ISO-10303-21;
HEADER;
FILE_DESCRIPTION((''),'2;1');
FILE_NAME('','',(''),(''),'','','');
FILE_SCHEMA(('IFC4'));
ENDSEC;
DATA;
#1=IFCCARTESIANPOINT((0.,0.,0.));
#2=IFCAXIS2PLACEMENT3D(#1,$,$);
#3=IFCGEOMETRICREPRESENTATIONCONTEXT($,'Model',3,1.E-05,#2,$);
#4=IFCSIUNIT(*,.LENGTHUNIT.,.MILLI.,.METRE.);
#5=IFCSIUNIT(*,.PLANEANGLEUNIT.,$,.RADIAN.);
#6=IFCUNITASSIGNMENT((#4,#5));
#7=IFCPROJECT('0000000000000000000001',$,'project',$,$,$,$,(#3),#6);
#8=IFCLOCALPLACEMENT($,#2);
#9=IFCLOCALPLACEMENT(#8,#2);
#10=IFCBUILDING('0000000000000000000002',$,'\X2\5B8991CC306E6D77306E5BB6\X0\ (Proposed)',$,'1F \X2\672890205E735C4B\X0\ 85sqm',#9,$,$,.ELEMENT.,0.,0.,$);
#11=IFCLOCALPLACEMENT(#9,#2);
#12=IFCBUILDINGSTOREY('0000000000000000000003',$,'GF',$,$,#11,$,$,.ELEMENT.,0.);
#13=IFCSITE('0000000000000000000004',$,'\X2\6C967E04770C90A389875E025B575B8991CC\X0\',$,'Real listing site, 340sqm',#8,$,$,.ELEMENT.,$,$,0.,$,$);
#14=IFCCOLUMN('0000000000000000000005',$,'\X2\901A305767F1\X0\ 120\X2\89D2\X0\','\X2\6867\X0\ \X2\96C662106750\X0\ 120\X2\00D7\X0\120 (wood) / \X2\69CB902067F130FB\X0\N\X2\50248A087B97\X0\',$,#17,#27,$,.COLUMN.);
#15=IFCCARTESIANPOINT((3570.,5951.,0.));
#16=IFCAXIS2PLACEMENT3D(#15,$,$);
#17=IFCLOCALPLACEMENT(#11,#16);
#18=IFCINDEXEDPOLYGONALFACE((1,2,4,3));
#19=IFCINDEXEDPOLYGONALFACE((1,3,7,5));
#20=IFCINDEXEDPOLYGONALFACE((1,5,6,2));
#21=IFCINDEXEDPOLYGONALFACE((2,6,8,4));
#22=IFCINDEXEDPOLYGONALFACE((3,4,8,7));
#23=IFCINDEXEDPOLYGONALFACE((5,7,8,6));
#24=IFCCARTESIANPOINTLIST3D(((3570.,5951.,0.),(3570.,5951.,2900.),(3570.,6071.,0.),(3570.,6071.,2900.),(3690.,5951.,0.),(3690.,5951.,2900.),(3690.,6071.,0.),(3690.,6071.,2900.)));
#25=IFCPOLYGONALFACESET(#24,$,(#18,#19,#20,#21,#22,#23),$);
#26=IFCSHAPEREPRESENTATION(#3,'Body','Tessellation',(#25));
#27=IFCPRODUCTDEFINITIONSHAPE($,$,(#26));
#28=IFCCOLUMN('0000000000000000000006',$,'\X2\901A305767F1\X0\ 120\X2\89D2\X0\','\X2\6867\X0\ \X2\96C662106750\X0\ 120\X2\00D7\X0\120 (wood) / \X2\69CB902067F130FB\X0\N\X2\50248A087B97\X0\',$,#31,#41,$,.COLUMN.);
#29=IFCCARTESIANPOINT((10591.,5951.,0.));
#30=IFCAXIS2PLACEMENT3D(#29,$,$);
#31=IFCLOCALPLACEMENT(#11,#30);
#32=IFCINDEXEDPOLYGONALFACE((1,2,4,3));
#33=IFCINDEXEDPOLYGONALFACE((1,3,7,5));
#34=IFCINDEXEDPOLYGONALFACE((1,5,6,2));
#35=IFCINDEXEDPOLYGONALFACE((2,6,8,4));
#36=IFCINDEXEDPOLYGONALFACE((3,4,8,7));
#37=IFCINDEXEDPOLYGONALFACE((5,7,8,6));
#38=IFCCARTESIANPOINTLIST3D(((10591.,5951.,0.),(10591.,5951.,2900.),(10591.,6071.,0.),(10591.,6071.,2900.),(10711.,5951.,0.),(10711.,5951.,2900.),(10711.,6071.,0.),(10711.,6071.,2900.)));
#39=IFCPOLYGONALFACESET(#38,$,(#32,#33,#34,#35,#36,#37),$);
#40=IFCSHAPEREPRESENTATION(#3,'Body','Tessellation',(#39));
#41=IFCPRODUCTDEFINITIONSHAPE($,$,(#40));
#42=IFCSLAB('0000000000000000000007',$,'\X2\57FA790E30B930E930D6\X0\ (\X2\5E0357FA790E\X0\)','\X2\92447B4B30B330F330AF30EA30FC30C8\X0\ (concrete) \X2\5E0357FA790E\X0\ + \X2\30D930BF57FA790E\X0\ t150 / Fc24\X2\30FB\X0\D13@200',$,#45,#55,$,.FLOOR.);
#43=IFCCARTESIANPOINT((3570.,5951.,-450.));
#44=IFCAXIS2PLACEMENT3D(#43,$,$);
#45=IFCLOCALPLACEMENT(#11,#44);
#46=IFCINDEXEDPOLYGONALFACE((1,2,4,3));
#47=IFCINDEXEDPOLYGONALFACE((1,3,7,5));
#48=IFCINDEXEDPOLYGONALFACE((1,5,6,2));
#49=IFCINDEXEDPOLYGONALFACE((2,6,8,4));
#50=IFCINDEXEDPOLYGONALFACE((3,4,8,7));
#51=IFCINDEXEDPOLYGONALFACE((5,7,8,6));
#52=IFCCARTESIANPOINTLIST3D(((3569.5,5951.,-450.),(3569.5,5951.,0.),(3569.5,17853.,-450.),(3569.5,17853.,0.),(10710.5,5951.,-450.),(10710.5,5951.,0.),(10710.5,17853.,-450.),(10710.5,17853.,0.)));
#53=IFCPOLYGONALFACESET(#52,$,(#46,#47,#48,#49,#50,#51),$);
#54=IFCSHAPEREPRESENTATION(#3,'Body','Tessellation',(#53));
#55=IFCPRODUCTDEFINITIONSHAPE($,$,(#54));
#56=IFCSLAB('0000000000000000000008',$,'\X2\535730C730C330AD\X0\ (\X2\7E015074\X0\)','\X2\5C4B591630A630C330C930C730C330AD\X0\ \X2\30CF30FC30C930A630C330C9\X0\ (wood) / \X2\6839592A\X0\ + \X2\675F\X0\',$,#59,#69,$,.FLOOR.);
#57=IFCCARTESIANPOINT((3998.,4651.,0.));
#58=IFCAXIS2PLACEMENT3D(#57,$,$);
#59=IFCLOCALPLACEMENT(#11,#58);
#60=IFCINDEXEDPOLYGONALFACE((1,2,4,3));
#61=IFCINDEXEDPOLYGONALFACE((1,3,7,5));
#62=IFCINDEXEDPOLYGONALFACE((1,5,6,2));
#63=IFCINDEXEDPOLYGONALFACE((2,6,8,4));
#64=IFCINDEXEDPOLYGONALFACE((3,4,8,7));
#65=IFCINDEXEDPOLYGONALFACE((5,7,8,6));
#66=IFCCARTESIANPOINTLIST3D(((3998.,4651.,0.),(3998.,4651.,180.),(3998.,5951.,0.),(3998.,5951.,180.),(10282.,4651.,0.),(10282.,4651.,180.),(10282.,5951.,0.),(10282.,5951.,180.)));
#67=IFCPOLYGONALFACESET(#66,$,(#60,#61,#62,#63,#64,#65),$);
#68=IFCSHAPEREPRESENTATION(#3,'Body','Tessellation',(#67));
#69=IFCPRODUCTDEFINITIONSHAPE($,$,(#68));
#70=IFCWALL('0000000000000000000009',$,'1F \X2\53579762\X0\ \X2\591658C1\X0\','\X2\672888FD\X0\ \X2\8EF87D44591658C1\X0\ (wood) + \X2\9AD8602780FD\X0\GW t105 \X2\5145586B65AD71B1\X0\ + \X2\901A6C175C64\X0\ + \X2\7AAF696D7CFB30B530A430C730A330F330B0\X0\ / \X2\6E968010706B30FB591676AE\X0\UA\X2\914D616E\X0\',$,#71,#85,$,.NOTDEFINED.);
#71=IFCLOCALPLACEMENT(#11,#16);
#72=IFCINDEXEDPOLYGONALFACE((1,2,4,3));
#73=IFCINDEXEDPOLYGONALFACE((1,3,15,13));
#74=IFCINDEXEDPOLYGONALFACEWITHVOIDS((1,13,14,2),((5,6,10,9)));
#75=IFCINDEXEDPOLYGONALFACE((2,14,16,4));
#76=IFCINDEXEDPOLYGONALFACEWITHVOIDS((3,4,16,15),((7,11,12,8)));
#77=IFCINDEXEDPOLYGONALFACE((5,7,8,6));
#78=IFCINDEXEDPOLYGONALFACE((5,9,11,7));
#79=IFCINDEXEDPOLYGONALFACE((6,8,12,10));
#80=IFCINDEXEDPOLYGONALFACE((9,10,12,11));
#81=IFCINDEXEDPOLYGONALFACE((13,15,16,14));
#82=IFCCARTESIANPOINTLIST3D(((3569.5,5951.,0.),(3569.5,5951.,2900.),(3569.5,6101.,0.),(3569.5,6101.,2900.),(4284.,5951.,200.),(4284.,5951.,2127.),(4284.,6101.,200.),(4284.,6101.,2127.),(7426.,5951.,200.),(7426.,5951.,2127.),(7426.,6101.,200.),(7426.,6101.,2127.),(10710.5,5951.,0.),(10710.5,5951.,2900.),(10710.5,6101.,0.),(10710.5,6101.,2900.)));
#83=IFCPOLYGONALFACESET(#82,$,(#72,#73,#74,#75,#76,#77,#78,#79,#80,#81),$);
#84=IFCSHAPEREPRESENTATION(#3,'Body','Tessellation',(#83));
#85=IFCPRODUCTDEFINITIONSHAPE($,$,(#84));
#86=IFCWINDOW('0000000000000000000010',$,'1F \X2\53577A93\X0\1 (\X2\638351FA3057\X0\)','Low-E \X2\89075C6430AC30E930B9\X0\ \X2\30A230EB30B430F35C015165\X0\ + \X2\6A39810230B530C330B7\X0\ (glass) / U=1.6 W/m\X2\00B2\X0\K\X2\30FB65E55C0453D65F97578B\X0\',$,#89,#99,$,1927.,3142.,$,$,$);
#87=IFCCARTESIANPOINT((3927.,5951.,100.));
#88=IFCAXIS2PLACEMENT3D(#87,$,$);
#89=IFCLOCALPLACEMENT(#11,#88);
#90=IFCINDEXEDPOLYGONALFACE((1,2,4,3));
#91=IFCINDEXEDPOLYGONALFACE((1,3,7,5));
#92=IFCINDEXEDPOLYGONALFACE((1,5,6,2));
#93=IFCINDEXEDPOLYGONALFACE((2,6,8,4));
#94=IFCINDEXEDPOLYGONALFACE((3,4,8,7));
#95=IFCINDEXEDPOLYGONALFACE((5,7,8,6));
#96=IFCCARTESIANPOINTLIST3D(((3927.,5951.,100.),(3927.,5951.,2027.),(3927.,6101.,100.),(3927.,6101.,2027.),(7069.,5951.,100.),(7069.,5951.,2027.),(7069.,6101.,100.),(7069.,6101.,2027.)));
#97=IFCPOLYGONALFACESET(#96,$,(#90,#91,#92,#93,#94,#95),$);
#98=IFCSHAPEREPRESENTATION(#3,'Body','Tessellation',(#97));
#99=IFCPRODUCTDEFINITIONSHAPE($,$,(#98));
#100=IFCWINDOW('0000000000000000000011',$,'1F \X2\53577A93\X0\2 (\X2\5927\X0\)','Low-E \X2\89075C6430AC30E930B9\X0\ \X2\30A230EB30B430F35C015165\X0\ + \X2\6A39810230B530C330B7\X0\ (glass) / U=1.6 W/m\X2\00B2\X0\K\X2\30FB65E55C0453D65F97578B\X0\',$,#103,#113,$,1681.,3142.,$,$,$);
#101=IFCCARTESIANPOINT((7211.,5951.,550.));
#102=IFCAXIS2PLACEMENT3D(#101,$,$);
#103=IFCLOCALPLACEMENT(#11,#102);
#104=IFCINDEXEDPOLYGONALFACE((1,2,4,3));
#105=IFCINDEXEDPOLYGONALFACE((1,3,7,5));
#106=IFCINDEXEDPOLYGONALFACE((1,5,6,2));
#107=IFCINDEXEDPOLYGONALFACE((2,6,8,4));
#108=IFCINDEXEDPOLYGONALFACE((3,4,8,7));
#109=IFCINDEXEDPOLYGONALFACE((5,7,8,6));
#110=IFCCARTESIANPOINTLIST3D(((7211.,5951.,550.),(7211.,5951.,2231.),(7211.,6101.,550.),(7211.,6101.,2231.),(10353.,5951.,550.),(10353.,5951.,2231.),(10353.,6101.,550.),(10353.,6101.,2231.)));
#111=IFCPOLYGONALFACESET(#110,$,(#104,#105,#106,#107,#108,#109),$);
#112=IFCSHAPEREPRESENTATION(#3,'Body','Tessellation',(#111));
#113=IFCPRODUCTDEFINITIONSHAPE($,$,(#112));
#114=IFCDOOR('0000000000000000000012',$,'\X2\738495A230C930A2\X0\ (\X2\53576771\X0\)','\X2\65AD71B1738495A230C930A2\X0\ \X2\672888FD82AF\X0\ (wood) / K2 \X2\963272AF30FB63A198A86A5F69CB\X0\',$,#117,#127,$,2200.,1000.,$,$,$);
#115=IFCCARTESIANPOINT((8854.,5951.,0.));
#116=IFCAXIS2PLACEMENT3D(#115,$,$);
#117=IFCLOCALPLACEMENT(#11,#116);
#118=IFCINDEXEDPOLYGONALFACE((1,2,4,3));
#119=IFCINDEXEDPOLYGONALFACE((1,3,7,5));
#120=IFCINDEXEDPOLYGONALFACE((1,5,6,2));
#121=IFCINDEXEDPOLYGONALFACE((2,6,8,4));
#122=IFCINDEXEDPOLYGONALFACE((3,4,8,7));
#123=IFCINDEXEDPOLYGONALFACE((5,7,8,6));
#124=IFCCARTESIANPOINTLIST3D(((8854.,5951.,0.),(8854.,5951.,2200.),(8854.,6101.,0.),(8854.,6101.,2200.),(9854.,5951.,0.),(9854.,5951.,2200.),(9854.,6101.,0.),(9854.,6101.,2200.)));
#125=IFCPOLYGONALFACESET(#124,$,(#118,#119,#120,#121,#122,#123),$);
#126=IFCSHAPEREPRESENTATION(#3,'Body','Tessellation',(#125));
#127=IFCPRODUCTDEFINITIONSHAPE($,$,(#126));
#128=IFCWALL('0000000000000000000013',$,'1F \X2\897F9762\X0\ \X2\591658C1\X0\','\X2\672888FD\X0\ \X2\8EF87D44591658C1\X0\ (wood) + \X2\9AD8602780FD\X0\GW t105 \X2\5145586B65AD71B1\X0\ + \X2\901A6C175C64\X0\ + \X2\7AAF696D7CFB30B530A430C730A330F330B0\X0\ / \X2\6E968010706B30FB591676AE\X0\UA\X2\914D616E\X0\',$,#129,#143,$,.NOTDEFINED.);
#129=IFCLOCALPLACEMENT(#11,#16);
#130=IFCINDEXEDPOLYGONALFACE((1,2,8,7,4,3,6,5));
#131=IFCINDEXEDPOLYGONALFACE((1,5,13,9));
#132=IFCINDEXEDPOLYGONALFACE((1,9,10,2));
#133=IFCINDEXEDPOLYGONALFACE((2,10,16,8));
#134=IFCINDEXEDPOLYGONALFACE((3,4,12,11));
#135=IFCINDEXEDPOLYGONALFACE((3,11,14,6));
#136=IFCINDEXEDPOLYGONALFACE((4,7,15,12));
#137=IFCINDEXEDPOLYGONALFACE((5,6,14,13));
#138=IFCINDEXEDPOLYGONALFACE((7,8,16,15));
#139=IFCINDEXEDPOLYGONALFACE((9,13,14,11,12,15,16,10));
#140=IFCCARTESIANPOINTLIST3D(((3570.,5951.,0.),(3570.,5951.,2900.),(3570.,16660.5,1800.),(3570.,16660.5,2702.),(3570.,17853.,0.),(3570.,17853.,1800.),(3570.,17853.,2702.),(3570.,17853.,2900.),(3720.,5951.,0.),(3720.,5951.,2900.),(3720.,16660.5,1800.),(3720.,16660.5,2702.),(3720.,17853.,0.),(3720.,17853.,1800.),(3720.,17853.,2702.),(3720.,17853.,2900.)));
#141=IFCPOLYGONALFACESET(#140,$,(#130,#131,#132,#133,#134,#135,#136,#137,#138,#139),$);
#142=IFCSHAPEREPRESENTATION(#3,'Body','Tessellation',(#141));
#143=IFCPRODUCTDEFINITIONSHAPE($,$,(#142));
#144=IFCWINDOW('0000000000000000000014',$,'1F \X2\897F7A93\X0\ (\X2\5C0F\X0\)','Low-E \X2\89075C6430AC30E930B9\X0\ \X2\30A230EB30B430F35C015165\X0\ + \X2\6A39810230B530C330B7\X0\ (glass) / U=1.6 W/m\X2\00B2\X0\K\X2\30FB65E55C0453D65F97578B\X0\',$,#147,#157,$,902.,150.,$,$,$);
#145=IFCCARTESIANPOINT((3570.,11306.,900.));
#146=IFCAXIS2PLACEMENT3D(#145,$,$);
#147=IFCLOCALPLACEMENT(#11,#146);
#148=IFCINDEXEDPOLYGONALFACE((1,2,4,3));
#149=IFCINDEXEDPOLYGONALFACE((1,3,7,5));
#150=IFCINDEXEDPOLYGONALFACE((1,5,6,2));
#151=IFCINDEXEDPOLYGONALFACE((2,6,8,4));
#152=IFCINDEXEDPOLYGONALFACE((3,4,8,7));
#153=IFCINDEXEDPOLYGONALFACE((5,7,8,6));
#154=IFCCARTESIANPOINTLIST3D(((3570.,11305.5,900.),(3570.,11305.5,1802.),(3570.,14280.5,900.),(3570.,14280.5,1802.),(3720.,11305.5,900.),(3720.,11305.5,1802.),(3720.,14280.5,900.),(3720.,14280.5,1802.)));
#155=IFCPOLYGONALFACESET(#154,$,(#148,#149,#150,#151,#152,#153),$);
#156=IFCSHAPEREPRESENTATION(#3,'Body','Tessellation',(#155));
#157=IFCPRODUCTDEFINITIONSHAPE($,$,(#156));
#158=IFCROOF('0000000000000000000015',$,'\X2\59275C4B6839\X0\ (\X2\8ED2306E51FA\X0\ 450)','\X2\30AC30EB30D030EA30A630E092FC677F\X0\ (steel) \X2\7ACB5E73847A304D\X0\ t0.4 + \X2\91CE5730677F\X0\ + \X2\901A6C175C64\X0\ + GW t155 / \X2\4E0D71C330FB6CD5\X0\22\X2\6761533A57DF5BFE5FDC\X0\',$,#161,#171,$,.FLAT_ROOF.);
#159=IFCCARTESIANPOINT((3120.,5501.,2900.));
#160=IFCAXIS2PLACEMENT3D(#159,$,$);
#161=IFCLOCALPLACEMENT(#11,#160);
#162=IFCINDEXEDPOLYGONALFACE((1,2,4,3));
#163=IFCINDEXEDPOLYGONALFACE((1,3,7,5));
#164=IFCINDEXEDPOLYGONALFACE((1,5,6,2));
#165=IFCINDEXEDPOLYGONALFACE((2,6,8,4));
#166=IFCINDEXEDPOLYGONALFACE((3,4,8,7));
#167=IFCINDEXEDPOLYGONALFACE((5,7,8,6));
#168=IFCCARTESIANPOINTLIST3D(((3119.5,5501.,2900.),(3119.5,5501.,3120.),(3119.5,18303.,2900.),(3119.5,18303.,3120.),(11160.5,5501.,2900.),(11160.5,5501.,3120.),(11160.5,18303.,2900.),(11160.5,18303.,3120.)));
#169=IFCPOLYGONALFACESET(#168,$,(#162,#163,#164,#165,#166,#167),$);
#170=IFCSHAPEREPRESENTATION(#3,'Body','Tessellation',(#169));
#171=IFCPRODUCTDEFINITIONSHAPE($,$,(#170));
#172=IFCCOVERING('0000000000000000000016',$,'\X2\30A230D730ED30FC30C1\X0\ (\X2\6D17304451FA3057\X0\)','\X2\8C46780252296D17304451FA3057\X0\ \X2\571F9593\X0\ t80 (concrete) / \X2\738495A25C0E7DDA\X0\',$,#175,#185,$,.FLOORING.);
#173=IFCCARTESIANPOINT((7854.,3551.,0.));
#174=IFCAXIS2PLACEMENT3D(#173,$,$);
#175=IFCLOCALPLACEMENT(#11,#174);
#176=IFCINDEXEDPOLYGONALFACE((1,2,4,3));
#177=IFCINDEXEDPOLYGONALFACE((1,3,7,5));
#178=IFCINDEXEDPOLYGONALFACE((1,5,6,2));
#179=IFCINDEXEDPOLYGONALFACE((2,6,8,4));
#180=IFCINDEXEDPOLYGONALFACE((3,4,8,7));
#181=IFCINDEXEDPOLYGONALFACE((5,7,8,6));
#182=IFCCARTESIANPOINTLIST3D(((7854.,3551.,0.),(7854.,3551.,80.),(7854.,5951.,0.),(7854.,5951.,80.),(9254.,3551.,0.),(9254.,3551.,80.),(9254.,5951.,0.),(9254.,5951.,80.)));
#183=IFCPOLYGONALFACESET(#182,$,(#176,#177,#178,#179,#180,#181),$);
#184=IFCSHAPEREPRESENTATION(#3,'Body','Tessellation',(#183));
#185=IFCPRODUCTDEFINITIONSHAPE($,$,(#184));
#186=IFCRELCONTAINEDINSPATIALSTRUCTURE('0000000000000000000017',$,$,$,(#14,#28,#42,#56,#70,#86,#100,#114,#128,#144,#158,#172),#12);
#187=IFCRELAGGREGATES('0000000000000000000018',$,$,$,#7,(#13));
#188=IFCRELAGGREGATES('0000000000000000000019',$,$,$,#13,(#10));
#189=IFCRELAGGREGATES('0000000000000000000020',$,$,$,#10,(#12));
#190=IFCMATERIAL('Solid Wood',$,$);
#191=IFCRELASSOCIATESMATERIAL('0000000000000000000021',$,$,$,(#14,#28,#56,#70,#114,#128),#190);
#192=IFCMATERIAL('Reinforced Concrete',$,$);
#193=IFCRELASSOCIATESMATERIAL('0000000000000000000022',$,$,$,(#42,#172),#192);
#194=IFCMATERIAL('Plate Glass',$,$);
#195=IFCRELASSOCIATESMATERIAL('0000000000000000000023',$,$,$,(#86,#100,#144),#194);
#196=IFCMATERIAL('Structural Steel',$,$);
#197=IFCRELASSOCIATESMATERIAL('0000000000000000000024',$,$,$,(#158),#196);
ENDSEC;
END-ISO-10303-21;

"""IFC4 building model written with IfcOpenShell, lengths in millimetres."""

from ifc_helpers import new_model, si_unit, frame, frame_2d, origin, place, context, project, spatial, rectangle, extrude, material, element, fill, save


model = new_model("IFC4")

# Units and contexts
model_context = context("Model", 3, precision=1e-05, world=origin())
ifc_project = project(units=[si_unit("LENGTHUNIT", "METRE", prefix="MILLI"), si_unit("PLANEANGLEUNIT", "RADIAN")], contexts=[model_context])

# Site, building, storey
site_placement = place(None, origin())
site = spatial("IfcSite", under=ifc_project, at=site_placement, Name="沖縄県那覇市字安里", ObjectType="Real listing site, 340sqm", CompositionType="ELEMENT", RefElevation=0.0)
building_placement = place(site_placement, origin())
building = spatial("IfcBuilding", under=site, at=building_placement, Name="安里の海の家 (Proposed)", ObjectType="1F 木造平屋 85sqm", CompositionType="ELEMENT", ElevationOfRefHeight=0.0, ElevationOfTerrain=0.0)
storey_placement = place(building_placement, origin())
storey = spatial("IfcBuildingStorey", under=building, at=storey_placement, Name="GF", CompositionType="ELEMENT", Elevation=0.0)

# Columns
ifc_material_1 = material(Name="Solid Wood")
column_1_placement = place(storey_placement, frame((3570.0, 5951.0, 0.0)))
element("IfcColumn", 1, at=column_1_placement, inside=storey, material=ifc_material_1, Name="通し柱 120角", Description="桧 集成材 120×120 (wood) / 構造柱・N値計算", PredefinedType="COLUMN", context=model_context, shape_type="SweptSolid", body=[
    extrude(rectangle(XDim=120.0, YDim=120.0, at=frame_2d((60.0, 60.0))), frame((3570.0, 5951.0, 0.0)), (0.0, 0.0, 1.0), 2900.0),
])
column_2_placement = place(storey_placement, frame((10591.0, 5951.0, 0.0)))
element("IfcColumn", 2, at=column_2_placement, inside=storey, material=ifc_material_1, Name="通し柱 120角", Description="桧 集成材 120×120 (wood) / 構造柱・N値計算", PredefinedType="COLUMN", context=model_context, shape_type="SweptSolid", body=[
    extrude(rectangle(XDim=120.0, YDim=120.0, at=frame_2d((60.0, 60.0))), frame((10591.0, 5951.0, 0.0)), (0.0, 0.0, 1.0), 2900.0),
])

# Slabs
ifc_material_2 = material(Name="Reinforced Concrete")
slab_1_placement = place(storey_placement, frame((3570.0, 5951.0, -450.0)))
element("IfcSlab", 3, at=slab_1_placement, inside=storey, material=ifc_material_2, Name="基礎スラブ (布基礎)", Description="鉄筋コンクリート (concrete) 布基礎 + ベタ基礎 t150 / Fc24・D13@200", PredefinedType="FLOOR", context=model_context, shape_type="SweptSolid", body=[
    extrude(rectangle(XDim=7141.0, YDim=11902.0, at=frame_2d((3570.0, 5951.0))), frame((3570.0, 5951.0, -450.0)), (0.0, 0.0, 1.0), 450.0),
])
slab_2_placement = place(storey_placement, frame((3998.0, 4651.0, 0.0)))
element("IfcSlab", 4, at=slab_2_placement, inside=storey, material=ifc_material_1, Name="南デッキ (縁側)", Description="屋外ウッドデッキ ハードウッド (wood) / 根太 + 束", PredefinedType="FLOOR", context=model_context, shape_type="SweptSolid", body=[
    extrude(rectangle(XDim=6284.0, YDim=1300.0, at=frame_2d((3142.0, 650.0))), frame((3998.0, 4651.0, 0.0)), (0.0, 0.0, 1.0), 180.0),
])

# Wall, openings, windows, door
wall_1_placement = place(storey_placement, frame((3570.0, 5951.0, 0.0)))
wall_1 = element("IfcWall", 5, at=wall_1_placement, inside=storey, material=ifc_material_1, Name="1F 南面 外壁", Description="木製 軸組外壁 (wood) + 高性能GW t105 充填断熱 + 通気層 + 窯業系サイディング / 準耐火・外皮UA配慮", PredefinedType="NOTDEFINED", context=model_context, shape_type="SweptSolid", body=[
    extrude(rectangle(XDim=7141.0, YDim=150.0, at=frame_2d((3570.0, 75.0))), frame((3570.0, 5951.0, 0.0)), (0.0, 0.0, 1.0), 2900.0),
])
opening_1_placement = place(storey_placement, frame((3927.0, 5951.0, 100.0)))
opening_1 = element("IfcOpeningElement", 6, at=opening_1_placement, cuts=wall_1, PredefinedType="NOTDEFINED", context=model_context, shape_type="SweptSolid", body=[
    extrude(rectangle(XDim=3142.0, YDim=150.0, at=frame_2d((1571.0, 75.0))), frame((3927.0, 5951.0, 100.0)), (0.0, 0.0, 1.0), 1927.0),
])
opening_2_placement = place(storey_placement, frame((7211.0, 5951.0, 550.0)))
opening_2 = element("IfcOpeningElement", 7, at=opening_2_placement, cuts=wall_1, PredefinedType="NOTDEFINED", context=model_context, shape_type="SweptSolid", body=[
    extrude(rectangle(XDim=3142.0, YDim=150.0, at=frame_2d((1571.0, 75.0))), frame((7211.0, 5951.0, 550.0)), (0.0, 0.0, 1.0), 1681.0),
])
opening_3_placement = place(storey_placement, frame((8854.0, 5951.0, 0.0)))
opening_3 = element("IfcOpeningElement", 8, at=opening_3_placement, cuts=wall_1, PredefinedType="NOTDEFINED", context=model_context, shape_type="SweptSolid", body=[
    extrude(rectangle(XDim=1000.0, YDim=150.0, at=frame_2d((500.0, 75.0))), frame((8854.0, 5951.0, 0.0)), (0.0, 0.0, 1.0), 2200.0),
])
ifc_material_3 = material(Name="Plate Glass")
window_1_placement = place(storey_placement, frame((3927.0, 5951.0, 100.0)))
window_1 = element("IfcWindow", 9, at=window_1_placement, inside=storey, material=ifc_material_3, Name="1F 南窓1 (掃出し)", Description="Low-E 複層ガラス アルゴン封入 + 樹脂サッシ (glass) / U=1.6 W/m²K・日射取得型", OverallHeight=1927.0, OverallWidth=3142.0, context=model_context, shape_type="SweptSolid", body=[
    extrude(rectangle(XDim=3142.0, YDim=150.0, at=frame_2d((1571.0, 75.0))), frame((3927.0, 5951.0, 100.0)), (0.0, 0.0, 1.0), 1927.0),
])
fill(opening_1, window_1)
window_2_placement = place(storey_placement, frame((7211.0, 5951.0, 550.0)))
window_2 = element("IfcWindow", 10, at=window_2_placement, inside=storey, material=ifc_material_3, Name="1F 南窓2 (大)", Description="Low-E 複層ガラス アルゴン封入 + 樹脂サッシ (glass) / U=1.6 W/m²K・日射取得型", OverallHeight=1681.0, OverallWidth=3142.0, context=model_context, shape_type="SweptSolid", body=[
    extrude(rectangle(XDim=3142.0, YDim=150.0, at=frame_2d((1571.0, 75.0))), frame((7211.0, 5951.0, 550.0)), (0.0, 0.0, 1.0), 1681.0),
])
fill(opening_2, window_2)
door_placement = place(storey_placement, frame((8854.0, 5951.0, 0.0)))
door = element("IfcDoor", 11, at=door_placement, inside=storey, material=ifc_material_1, Name="玄関ドア (南東)", Description="断熱玄関ドア 木製芯 (wood) / K2 防犯・採風機構", OverallHeight=2200.0, OverallWidth=1000.0, context=model_context, shape_type="SweptSolid", body=[
    extrude(rectangle(XDim=1000.0, YDim=150.0, at=frame_2d((500.0, 75.0))), frame((8854.0, 5951.0, 0.0)), (0.0, 0.0, 1.0), 2200.0),
])
fill(opening_3, door)

# Wall, opening, window
wall_2_placement = place(storey_placement, frame((3570.0, 5951.0, 0.0)))
wall_2 = element("IfcWall", 12, at=wall_2_placement, inside=storey, material=ifc_material_1, Name="1F 西面 外壁", Description="木製 軸組外壁 (wood) + 高性能GW t105 充填断熱 + 通気層 + 窯業系サイディング / 準耐火・外皮UA配慮", PredefinedType="NOTDEFINED", context=model_context, shape_type="SweptSolid", body=[
    extrude(rectangle(XDim=150.0, YDim=11902.0, at=frame_2d((75.0, 5951.0))), frame((3570.0, 5951.0, 0.0)), (0.0, 0.0, 1.0), 2900.0),
])
opening_4_placement = place(storey_placement, frame((3570.0, 11306.0, 900.0)))
opening_4 = element("IfcOpeningElement", 13, at=opening_4_placement, cuts=wall_2, PredefinedType="NOTDEFINED", context=model_context, shape_type="SweptSolid", body=[
    extrude(rectangle(XDim=150.0, YDim=2975.0, at=frame_2d((75.0, 1487.0))), frame((3570.0, 11306.0, 900.0)), (0.0, 0.0, 1.0), 902.0),
])
window_3_placement = place(storey_placement, frame((3570.0, 11306.0, 900.0)))
window_3 = element("IfcWindow", 14, at=window_3_placement, inside=storey, material=ifc_material_3, Name="1F 西窓 (小)", Description="Low-E 複層ガラス アルゴン封入 + 樹脂サッシ (glass) / U=1.6 W/m²K・日射取得型", OverallHeight=902.0, OverallWidth=150.0, context=model_context, shape_type="SweptSolid", body=[
    extrude(rectangle(XDim=150.0, YDim=2975.0, at=frame_2d((75.0, 1487.0))), frame((3570.0, 11306.0, 900.0)), (0.0, 0.0, 1.0), 902.0),
])
fill(opening_4, window_3)

# Roof
ifc_material_4 = material(Name="Structural Steel")
roof_placement = place(storey_placement, frame((3120.0, 5501.0, 2900.0)))
element("IfcRoof", 15, at=roof_placement, inside=storey, material=ifc_material_4, Name="大屋根 (軒の出 450)", Description="ガルバリウム鋼板 (steel) 立平葺き t0.4 + 野地板 + 通気層 + GW t155 / 不燃・法22条区域対応", PredefinedType="FLAT_ROOF", context=model_context, shape_type="SweptSolid", body=[
    extrude(rectangle(XDim=8041.0, YDim=12802.0, at=frame_2d((4020.0, 6401.0))), frame((3120.0, 5501.0, 2900.0)), (0.0, 0.0, 1.0), 220.0),
])

# Covering
covering_1_placement = place(storey_placement, frame((7854.0, 3551.0, 0.0)))
element("IfcCovering", 16, at=covering_1_placement, inside=storey, material=ifc_material_2, Name="アプローチ (洗い出し)", Description="豆砂利洗い出し 土間 t80 (concrete) / 玄関導線", PredefinedType="FLOORING", context=model_context, shape_type="SweptSolid", body=[
    extrude(rectangle(XDim=1400.0, YDim=2400.0, at=frame_2d((700.0, 1200.0))), frame((7854.0, 3551.0, 0.0)), (0.0, 0.0, 1.0), 80.0),
])

save(model, "model.ifc")
